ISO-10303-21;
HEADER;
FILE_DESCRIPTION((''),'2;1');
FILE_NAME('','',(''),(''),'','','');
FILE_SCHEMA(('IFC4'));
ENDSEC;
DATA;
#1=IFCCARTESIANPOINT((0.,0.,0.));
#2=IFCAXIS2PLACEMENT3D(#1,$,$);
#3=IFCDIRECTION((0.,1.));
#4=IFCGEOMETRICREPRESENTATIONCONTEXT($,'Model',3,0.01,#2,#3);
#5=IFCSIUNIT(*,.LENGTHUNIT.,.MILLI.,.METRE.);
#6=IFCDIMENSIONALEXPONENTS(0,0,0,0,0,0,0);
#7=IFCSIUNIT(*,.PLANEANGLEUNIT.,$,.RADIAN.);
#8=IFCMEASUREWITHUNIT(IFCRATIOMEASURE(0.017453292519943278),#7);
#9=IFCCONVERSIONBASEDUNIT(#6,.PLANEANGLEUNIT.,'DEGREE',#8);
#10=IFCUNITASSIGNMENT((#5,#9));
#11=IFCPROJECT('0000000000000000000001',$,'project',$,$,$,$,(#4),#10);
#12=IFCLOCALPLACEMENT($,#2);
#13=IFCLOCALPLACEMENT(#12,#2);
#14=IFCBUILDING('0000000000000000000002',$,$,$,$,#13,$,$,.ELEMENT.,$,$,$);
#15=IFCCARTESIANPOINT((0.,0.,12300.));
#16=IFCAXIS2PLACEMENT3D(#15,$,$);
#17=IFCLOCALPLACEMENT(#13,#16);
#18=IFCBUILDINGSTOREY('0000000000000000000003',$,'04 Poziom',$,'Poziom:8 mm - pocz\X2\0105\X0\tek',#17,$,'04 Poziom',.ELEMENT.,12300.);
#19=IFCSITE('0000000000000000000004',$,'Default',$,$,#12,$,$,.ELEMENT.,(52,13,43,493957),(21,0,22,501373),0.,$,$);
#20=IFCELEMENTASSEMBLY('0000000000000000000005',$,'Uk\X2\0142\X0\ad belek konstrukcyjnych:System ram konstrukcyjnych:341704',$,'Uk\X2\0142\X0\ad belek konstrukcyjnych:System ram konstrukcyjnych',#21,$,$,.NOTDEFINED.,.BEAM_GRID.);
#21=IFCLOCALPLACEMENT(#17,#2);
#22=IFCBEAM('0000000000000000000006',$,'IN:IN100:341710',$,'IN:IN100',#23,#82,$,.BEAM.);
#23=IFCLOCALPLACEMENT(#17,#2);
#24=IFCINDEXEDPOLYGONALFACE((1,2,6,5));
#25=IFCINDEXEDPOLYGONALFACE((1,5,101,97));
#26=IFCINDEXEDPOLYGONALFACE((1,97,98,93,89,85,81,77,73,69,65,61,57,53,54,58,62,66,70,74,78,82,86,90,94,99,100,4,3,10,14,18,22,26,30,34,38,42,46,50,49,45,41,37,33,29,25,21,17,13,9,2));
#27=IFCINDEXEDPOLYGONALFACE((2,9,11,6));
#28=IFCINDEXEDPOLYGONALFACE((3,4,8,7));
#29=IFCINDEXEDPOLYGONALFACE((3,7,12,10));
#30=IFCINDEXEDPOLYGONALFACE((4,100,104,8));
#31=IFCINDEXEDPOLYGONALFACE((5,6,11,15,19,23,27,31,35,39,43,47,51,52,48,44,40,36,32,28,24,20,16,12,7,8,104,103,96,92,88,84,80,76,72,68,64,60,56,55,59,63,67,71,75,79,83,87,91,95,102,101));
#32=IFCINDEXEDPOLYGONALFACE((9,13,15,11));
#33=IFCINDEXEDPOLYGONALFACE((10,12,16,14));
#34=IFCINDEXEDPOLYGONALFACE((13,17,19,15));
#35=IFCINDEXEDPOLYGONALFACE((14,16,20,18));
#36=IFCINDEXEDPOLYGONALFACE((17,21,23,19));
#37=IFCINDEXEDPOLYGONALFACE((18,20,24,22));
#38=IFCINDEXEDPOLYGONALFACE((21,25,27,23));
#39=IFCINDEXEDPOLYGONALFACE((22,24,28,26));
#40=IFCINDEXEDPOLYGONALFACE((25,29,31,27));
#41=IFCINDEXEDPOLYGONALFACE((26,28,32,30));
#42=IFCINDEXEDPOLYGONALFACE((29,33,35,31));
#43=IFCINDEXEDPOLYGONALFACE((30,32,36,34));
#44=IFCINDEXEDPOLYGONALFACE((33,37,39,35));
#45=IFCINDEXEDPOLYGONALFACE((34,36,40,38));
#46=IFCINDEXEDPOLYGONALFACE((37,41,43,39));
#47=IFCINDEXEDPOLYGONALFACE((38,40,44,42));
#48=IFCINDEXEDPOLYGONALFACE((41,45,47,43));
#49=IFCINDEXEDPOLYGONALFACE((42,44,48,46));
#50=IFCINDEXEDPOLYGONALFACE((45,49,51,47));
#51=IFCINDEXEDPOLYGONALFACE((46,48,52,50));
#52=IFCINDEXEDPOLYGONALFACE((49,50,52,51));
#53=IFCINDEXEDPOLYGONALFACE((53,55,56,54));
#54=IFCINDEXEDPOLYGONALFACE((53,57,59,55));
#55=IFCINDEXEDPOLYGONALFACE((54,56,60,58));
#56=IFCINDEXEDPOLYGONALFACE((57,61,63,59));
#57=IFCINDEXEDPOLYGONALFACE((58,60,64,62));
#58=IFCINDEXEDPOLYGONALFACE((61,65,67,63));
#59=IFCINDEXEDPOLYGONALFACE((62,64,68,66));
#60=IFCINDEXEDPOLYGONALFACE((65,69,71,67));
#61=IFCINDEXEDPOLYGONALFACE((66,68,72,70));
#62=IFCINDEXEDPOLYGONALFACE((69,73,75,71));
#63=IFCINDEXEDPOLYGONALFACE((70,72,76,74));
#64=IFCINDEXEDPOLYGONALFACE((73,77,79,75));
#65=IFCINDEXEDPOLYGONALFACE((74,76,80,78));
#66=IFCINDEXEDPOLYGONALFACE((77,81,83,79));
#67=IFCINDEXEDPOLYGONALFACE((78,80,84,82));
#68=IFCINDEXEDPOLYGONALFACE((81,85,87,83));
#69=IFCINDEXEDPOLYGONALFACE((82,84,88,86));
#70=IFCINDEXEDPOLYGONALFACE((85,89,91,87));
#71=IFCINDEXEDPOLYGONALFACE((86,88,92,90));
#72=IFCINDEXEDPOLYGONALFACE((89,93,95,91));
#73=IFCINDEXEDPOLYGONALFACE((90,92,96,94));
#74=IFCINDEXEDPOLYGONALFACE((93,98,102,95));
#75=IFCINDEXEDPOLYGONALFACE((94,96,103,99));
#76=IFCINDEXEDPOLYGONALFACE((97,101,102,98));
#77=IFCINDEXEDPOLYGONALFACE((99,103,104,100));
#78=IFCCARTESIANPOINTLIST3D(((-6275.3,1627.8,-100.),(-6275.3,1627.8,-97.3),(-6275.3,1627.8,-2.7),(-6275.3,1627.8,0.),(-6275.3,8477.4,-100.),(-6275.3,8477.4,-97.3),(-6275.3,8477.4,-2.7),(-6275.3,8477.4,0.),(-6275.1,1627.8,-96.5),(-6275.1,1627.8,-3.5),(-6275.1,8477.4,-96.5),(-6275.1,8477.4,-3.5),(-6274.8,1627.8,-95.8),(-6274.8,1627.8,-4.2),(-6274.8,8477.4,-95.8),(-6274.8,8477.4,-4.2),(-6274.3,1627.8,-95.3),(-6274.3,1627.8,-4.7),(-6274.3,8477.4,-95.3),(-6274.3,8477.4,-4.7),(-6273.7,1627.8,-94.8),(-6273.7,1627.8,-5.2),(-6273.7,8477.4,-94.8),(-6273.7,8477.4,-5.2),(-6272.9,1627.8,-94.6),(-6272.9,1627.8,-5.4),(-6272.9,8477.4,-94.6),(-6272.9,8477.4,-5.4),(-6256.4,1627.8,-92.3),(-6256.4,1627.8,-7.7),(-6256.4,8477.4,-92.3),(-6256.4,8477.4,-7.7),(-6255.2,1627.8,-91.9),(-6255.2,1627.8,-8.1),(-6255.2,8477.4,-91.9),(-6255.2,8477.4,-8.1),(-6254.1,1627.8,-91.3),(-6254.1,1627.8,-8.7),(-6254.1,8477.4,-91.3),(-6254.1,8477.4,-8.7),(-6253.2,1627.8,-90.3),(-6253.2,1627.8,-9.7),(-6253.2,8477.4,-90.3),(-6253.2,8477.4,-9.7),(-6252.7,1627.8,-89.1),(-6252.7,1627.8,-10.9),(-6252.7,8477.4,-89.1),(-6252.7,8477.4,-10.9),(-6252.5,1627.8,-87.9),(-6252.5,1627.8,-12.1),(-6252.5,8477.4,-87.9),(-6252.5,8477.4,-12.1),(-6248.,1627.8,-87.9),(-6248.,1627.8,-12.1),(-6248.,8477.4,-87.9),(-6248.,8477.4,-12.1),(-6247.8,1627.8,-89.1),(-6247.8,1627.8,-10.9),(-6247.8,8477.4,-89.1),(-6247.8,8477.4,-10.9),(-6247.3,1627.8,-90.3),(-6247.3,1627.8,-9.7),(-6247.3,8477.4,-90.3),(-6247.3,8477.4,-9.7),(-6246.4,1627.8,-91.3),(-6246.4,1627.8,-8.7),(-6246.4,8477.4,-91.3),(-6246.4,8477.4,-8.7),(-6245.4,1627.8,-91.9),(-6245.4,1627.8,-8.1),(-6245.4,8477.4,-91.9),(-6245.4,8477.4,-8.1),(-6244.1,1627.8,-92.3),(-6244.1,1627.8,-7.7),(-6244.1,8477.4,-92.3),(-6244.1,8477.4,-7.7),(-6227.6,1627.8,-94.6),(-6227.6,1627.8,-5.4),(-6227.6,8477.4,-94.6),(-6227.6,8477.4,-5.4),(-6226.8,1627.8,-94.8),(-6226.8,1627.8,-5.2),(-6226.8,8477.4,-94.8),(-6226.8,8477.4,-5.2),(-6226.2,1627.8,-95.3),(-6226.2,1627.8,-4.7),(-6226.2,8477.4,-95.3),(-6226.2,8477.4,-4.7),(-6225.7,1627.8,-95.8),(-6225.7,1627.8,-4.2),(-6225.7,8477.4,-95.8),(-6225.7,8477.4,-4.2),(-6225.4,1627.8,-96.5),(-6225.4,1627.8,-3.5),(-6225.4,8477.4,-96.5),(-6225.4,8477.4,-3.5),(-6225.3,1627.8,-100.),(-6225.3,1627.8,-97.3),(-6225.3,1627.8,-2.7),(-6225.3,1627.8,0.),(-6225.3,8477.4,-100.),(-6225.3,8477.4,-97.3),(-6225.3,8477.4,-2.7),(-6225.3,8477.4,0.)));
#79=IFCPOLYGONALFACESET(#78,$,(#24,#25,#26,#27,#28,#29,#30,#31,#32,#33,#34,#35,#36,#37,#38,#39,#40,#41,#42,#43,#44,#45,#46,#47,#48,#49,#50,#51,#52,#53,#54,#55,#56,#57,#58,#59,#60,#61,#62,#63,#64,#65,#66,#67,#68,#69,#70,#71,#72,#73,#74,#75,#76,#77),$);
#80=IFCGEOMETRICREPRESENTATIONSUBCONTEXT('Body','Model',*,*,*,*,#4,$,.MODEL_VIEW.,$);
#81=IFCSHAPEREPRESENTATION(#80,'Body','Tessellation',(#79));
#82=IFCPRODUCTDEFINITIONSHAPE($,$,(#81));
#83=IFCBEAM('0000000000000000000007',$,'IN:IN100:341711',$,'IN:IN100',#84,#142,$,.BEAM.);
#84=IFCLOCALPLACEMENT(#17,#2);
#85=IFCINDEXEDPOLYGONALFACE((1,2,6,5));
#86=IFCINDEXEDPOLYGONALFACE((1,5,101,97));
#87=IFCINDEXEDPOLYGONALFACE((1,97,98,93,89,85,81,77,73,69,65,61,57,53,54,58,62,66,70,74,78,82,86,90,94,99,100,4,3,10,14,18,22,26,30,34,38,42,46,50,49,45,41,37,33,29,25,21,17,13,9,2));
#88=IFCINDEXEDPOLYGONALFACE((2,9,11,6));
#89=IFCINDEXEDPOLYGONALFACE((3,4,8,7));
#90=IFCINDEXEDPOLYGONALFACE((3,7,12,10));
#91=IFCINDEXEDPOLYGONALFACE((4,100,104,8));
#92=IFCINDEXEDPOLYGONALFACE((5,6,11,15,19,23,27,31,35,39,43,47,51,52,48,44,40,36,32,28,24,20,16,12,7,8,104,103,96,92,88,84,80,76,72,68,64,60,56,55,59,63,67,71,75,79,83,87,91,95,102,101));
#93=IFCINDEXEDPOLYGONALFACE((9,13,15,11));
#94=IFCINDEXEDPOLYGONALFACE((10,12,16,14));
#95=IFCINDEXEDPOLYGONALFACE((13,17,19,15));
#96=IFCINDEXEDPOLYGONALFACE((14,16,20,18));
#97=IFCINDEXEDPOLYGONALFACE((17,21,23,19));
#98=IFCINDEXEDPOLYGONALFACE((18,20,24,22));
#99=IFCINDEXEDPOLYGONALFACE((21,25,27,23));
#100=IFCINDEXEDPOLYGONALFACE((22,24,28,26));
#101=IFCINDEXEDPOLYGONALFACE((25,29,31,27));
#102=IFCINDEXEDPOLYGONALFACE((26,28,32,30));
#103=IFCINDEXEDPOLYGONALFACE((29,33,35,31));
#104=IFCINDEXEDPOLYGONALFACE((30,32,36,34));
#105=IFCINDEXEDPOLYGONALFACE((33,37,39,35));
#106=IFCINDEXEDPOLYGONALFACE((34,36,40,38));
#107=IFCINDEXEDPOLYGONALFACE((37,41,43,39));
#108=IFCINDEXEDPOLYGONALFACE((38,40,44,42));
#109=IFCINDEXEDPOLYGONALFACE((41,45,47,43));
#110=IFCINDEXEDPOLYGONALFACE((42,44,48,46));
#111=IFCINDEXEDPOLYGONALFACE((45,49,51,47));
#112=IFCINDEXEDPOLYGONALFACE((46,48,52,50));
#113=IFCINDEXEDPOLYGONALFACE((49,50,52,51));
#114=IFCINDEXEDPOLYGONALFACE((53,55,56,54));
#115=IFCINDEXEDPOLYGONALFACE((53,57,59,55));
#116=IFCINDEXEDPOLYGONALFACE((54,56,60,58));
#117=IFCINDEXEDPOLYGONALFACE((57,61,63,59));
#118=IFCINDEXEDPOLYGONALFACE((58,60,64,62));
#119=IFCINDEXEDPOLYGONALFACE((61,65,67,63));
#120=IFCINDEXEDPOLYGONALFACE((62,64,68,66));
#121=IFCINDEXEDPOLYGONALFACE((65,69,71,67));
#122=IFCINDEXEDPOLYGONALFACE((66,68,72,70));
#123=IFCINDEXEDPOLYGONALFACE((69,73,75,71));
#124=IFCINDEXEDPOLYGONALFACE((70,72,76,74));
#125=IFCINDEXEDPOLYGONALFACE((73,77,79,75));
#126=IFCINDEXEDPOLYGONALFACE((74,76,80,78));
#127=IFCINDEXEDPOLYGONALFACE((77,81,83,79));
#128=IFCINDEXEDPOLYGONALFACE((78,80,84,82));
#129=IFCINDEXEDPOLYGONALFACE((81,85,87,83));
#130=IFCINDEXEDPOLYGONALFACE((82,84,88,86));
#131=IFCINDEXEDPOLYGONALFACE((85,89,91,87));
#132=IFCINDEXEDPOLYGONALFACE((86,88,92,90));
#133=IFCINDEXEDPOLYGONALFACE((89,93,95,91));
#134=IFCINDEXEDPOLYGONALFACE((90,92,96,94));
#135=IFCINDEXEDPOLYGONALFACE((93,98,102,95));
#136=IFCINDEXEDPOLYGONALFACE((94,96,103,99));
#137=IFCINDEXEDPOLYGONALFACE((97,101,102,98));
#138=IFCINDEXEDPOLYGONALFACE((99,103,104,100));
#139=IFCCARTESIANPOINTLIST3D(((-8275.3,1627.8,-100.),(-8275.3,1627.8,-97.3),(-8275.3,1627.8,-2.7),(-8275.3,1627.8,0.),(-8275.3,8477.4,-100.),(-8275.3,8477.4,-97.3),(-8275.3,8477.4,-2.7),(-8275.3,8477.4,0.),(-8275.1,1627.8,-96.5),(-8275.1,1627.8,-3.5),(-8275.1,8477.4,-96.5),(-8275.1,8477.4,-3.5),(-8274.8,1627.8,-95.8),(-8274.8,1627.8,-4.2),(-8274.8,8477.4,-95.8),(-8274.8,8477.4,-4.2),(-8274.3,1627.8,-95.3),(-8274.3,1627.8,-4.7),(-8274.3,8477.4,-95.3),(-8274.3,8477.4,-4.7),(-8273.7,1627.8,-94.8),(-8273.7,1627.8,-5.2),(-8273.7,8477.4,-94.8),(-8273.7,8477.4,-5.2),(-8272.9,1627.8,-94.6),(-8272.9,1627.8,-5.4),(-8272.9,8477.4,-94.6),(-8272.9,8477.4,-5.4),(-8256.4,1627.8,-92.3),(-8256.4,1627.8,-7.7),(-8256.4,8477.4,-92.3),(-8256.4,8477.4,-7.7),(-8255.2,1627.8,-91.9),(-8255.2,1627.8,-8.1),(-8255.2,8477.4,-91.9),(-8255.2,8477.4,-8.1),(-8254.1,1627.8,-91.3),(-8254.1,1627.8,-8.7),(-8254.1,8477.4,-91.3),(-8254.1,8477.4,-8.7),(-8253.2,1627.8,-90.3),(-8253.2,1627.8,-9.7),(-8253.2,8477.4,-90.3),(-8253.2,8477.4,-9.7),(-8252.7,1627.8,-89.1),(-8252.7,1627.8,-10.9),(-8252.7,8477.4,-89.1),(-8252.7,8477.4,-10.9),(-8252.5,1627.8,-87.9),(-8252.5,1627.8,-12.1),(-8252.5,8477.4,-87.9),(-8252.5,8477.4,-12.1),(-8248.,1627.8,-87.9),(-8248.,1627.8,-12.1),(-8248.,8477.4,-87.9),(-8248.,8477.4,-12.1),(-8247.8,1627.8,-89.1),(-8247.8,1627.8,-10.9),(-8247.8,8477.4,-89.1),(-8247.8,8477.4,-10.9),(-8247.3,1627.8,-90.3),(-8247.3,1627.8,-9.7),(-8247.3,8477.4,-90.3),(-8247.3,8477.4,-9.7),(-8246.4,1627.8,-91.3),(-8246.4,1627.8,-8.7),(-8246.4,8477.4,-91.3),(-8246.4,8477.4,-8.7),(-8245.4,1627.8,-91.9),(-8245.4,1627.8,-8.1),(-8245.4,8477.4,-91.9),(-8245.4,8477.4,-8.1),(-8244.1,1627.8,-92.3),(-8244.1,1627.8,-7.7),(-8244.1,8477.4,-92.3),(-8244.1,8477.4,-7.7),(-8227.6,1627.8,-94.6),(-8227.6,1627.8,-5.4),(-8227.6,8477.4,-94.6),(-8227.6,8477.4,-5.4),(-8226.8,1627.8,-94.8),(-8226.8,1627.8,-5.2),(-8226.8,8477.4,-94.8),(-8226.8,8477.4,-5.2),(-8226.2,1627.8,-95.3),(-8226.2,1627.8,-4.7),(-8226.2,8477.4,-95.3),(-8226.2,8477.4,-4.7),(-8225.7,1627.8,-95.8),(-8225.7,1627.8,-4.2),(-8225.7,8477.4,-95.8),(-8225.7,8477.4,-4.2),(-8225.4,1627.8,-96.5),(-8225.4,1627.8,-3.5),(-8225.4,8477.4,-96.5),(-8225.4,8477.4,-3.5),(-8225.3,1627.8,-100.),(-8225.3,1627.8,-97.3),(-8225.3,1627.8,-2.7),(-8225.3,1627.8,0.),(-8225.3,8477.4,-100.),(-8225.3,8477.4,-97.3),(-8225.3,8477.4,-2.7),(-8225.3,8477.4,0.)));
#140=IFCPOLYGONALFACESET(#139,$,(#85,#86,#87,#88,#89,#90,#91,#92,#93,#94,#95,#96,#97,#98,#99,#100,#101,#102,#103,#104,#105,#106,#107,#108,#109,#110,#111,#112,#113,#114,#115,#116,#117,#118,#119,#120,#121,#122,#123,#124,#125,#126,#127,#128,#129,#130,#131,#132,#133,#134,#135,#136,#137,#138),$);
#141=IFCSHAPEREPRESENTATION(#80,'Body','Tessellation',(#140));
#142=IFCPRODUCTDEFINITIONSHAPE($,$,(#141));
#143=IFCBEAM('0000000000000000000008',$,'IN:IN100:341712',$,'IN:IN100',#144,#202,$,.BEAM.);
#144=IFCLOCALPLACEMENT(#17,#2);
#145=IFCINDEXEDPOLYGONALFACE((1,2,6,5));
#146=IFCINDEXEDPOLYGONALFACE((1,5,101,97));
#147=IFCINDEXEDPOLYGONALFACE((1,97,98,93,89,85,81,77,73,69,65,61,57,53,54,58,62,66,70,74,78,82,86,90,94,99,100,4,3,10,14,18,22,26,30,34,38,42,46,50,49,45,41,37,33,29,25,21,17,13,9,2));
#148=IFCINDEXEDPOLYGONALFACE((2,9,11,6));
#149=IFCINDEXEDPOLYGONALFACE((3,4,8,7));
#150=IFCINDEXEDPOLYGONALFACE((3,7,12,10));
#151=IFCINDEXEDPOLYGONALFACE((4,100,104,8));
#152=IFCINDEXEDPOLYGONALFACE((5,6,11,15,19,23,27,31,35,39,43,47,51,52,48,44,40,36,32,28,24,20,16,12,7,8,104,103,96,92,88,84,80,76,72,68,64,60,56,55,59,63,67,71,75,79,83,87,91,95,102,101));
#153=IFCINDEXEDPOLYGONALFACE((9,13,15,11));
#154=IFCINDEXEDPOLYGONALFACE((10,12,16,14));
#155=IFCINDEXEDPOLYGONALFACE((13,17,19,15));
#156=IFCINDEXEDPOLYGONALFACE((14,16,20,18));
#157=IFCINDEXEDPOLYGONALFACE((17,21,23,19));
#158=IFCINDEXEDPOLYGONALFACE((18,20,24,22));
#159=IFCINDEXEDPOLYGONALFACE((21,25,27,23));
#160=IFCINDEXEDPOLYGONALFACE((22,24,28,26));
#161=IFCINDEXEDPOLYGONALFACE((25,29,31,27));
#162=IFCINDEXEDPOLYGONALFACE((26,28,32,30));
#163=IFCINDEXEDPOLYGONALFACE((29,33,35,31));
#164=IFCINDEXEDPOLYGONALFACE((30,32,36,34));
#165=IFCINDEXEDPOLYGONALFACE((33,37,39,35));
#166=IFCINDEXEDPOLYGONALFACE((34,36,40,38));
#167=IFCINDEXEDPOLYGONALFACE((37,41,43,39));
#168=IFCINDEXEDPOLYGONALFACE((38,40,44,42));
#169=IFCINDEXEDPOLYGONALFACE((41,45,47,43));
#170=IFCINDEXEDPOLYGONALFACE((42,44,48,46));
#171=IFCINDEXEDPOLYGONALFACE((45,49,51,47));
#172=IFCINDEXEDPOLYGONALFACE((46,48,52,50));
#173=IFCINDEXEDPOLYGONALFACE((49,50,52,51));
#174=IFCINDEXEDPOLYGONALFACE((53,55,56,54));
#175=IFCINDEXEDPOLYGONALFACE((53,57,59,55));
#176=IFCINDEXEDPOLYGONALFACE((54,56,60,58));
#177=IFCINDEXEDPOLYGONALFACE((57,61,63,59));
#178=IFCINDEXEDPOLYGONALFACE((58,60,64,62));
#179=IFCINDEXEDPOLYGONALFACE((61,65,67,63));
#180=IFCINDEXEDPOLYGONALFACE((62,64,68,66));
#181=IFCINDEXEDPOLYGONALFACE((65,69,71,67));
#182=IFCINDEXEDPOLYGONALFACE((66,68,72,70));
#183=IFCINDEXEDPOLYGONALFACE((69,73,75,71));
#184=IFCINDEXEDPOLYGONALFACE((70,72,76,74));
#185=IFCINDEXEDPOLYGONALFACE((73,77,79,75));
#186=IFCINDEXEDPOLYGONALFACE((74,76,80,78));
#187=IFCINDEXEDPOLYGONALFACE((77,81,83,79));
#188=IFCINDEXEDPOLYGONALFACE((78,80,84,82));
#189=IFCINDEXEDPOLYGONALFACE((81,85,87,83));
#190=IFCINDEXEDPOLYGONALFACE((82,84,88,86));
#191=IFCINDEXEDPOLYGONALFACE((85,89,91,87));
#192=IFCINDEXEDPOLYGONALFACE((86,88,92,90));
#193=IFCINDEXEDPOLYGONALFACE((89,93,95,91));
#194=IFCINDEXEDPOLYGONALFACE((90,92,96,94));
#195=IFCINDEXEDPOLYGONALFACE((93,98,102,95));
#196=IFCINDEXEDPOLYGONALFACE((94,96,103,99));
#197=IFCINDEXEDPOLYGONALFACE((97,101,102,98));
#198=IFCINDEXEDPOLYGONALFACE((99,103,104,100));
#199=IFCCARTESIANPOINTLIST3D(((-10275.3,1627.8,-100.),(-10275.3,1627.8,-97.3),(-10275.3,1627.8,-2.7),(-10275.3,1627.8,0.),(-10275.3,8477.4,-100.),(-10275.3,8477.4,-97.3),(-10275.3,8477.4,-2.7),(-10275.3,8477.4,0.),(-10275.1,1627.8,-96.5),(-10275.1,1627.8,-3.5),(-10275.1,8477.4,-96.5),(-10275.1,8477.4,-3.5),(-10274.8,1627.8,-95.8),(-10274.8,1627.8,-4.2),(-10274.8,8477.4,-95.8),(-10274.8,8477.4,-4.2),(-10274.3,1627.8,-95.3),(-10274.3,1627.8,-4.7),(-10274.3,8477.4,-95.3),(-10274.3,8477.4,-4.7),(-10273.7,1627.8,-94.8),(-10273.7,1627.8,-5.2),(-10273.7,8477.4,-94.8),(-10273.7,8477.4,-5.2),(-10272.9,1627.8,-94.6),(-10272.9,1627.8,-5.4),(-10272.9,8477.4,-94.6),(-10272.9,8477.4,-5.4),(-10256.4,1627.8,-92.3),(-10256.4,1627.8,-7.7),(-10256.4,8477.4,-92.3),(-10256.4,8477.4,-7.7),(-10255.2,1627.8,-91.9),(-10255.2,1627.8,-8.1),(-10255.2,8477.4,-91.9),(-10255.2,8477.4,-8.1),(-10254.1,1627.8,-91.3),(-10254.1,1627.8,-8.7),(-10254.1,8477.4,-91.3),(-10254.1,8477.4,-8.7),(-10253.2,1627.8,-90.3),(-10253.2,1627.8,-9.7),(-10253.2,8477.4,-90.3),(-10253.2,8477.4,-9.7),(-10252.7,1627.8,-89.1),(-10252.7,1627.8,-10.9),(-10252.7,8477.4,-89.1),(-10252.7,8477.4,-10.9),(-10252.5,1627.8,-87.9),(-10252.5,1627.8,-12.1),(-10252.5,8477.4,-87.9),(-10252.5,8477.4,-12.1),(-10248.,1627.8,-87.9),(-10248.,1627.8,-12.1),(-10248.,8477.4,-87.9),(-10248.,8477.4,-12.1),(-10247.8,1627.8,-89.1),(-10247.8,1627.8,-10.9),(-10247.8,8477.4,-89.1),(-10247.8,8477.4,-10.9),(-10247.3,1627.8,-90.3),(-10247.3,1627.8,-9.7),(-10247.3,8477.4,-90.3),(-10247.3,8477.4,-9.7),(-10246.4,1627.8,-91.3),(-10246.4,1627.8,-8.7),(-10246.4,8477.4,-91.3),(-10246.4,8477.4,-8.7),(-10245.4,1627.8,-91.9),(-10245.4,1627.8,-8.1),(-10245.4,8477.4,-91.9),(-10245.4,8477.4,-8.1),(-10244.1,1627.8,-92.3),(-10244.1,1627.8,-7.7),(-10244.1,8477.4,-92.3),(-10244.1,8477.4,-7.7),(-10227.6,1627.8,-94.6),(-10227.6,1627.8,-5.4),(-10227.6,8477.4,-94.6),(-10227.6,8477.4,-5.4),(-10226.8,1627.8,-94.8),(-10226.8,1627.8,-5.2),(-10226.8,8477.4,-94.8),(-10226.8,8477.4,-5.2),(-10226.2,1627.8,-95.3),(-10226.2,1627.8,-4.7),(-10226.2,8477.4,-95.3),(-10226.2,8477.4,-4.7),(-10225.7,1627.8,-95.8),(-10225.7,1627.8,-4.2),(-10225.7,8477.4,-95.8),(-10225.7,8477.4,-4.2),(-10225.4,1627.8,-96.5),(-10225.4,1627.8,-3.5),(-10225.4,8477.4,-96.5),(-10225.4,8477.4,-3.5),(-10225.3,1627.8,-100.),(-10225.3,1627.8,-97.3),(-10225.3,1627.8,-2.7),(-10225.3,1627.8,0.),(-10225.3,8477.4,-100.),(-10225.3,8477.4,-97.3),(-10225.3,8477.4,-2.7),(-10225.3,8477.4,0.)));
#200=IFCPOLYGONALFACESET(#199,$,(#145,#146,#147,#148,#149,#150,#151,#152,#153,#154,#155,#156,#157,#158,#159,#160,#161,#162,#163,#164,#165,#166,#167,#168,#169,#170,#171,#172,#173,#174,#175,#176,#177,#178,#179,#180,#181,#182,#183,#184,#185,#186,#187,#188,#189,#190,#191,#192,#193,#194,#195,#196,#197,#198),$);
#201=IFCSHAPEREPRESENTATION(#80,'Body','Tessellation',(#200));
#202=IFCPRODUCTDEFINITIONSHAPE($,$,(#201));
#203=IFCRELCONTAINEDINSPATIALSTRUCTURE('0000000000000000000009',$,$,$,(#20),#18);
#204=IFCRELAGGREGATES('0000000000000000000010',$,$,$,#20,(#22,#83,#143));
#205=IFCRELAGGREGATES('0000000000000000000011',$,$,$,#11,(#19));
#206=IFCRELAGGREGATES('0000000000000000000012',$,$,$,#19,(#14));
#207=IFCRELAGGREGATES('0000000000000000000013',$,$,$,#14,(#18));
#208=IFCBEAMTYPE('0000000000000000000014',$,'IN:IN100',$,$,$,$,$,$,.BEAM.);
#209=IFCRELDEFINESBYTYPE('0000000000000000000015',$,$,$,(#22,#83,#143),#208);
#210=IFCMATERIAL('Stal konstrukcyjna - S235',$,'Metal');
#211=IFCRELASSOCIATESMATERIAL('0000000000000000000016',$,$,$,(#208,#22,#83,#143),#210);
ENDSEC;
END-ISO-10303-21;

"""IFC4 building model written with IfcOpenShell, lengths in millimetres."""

from ifc_helpers import new_model, entity, si_unit, converted_unit, direction, frame, origin, place, context, subcontext, project, spatial, line, arc, indexed_curve, outline, extrude, source, transform, mapped, material, type_object, type_shapes, element, aggregate, save


model = new_model("IFC4")

# Units and contexts
model_context = context("Model", 3, precision=0.01, world=origin(), true_north=direction((0.0, 1.0)))
body_context = subcontext(model_context, "Body", "Model", "MODEL_VIEW")
ifc_project = project(units=[si_unit("LENGTHUNIT", "METRE", prefix="MILLI"), converted_unit("PLANEANGLEUNIT", "DEGREE", entity("IfcRatioMeasure", 0.017453292519943278), si_unit("PLANEANGLEUNIT", "RADIAN"), dimensions=[0, 0, 0, 0, 0, 0, 0])], contexts=[model_context])

# Site, building, storey
site_placement = place(None, origin())
site = spatial("IfcSite", under=ifc_project, at=site_placement, Name="Default", CompositionType="ELEMENT", RefLatitude=(52, 13, 43, 493957), RefLongitude=(21, 0, 22, 501373), RefElevation=0.0)
building_placement = place(site_placement, origin())
building = spatial("IfcBuilding", under=site, at=building_placement, CompositionType="ELEMENT")
storey_placement = place(building_placement, frame((0.0, 0.0, 12300.0)))
storey = spatial("IfcBuildingStorey", under=building, at=storey_placement, Name="04 Poziom", ObjectType="Poziom:8 mm - początek", LongName="04 Poziom", CompositionType="ELEMENT", Elevation=12300.0)

# Shared definitions
ifc_material_1 = material(Name="Stal konstrukcyjna - S235", Category="Metal")

# Element assembly, beams
assembly_1_placement = place(storey_placement, origin())
assembly_1 = element("IfcElementAssembly", 1, at=assembly_1_placement, inside=storey, Name="Układ belek konstrukcyjnych:System ram konstrukcyjnych:341704", ObjectType="Układ belek konstrukcyjnych:System ram konstrukcyjnych", AssemblyPlace="NOTDEFINED", PredefinedType="BEAM_GRID")
beam_type_1 = type_object("IfcBeamType", Name="IN:IN100", PredefinedType="BEAM", material=ifc_material_1)
shared_shape_1 = source(origin(), body_context, "Body", "SweptSolid", [
    extrude(outline(indexed_curve([(47.3, -25.0), (50.0, -25.0), (50.0, 25.0), (47.3, 25.0), (45.5, 24.3), (44.6, 22.7), (42.3, 6.1), (40.8, 3.4), (37.9, 2.2), (-37.9, 2.2), (-40.8, 3.4), (-42.3, 6.1), (-44.6, 22.7), (-45.5, 24.3), (-47.3, 25.0), (-50.0, 25.0), (-50.0, -25.0), (-47.3, -25.0), (-45.5, -24.3), (-44.6, -22.7), (-42.3, -6.1), (-40.8, -3.4), (-37.9, -2.2), (37.9, -2.2), (40.8, -3.4), (42.3, -6.1), (44.6, -22.7), (45.5, -24.3)], segments=[line(1, 2, 3, 4), arc(4, 5, 6), line(6, 7), arc(7, 8, 9), line(9, 10), arc(10, 11, 12), line(12, 13), arc(13, 14, 15), line(15, 16, 17, 18), arc(18, 19, 20), line(20, 21), arc(21, 22, 23), line(23, 24), arc(24, 25, 26), line(26, 27), arc(27, 28, 1)], self_intersect=False)), frame((-3424.8, 0.0, 0.0), z_axis=(1.0, 0.0, 0.0), x_axis=(0.0, 0.0, -1.0)), (0.0, 0.0, 1.0), 6849.6),
])
type_shapes(beam_type_1, [shared_shape_1])
beam_1_placement = place(assembly_1_placement, frame((-6250.3, 5052.6, -50.0), z_axis=(0.0, 0.0, 1.0), x_axis=(0.0, -1.0, 0.0)))
beam_1 = element("IfcBeam", 2, at=beam_1_placement, type_object=beam_type_1, material=ifc_material_1, Name="IN:IN100:341710", ObjectType="IN:IN100", PredefinedType="BEAM", context=body_context, shape_type="MappedRepresentation", body=[
    mapped(shared_shape_1, transform((0.0, 0.0, 0.0), scale=1.0)),
])
beam_2_placement = place(assembly_1_placement, frame((-8250.3, 5052.6, -50.0), z_axis=(0.0, 0.0, 1.0), x_axis=(0.0, -1.0, 0.0)))
beam_2 = element("IfcBeam", 3, at=beam_2_placement, type_object=beam_type_1, material=ifc_material_1, Name="IN:IN100:341711", ObjectType="IN:IN100", PredefinedType="BEAM", context=body_context, shape_type="MappedRepresentation", body=[
    mapped(shared_shape_1, transform((0.0, 0.0, 0.0), scale=1.0)),
])
beam_3_placement = place(assembly_1_placement, frame((-10250.3, 5052.6, -50.0), z_axis=(0.0, 0.0, 1.0), x_axis=(0.0, -1.0, 0.0)))
beam_3 = element("IfcBeam", 4, at=beam_3_placement, type_object=beam_type_1, material=ifc_material_1, Name="IN:IN100:341712", ObjectType="IN:IN100", PredefinedType="BEAM", context=body_context, shape_type="MappedRepresentation", body=[
    mapped(shared_shape_1, transform((0.0, 0.0, 0.0), scale=1.0)),
])
aggregate(assembly_1, [beam_1, beam_2, beam_3])

save(model, "model.ifc")
